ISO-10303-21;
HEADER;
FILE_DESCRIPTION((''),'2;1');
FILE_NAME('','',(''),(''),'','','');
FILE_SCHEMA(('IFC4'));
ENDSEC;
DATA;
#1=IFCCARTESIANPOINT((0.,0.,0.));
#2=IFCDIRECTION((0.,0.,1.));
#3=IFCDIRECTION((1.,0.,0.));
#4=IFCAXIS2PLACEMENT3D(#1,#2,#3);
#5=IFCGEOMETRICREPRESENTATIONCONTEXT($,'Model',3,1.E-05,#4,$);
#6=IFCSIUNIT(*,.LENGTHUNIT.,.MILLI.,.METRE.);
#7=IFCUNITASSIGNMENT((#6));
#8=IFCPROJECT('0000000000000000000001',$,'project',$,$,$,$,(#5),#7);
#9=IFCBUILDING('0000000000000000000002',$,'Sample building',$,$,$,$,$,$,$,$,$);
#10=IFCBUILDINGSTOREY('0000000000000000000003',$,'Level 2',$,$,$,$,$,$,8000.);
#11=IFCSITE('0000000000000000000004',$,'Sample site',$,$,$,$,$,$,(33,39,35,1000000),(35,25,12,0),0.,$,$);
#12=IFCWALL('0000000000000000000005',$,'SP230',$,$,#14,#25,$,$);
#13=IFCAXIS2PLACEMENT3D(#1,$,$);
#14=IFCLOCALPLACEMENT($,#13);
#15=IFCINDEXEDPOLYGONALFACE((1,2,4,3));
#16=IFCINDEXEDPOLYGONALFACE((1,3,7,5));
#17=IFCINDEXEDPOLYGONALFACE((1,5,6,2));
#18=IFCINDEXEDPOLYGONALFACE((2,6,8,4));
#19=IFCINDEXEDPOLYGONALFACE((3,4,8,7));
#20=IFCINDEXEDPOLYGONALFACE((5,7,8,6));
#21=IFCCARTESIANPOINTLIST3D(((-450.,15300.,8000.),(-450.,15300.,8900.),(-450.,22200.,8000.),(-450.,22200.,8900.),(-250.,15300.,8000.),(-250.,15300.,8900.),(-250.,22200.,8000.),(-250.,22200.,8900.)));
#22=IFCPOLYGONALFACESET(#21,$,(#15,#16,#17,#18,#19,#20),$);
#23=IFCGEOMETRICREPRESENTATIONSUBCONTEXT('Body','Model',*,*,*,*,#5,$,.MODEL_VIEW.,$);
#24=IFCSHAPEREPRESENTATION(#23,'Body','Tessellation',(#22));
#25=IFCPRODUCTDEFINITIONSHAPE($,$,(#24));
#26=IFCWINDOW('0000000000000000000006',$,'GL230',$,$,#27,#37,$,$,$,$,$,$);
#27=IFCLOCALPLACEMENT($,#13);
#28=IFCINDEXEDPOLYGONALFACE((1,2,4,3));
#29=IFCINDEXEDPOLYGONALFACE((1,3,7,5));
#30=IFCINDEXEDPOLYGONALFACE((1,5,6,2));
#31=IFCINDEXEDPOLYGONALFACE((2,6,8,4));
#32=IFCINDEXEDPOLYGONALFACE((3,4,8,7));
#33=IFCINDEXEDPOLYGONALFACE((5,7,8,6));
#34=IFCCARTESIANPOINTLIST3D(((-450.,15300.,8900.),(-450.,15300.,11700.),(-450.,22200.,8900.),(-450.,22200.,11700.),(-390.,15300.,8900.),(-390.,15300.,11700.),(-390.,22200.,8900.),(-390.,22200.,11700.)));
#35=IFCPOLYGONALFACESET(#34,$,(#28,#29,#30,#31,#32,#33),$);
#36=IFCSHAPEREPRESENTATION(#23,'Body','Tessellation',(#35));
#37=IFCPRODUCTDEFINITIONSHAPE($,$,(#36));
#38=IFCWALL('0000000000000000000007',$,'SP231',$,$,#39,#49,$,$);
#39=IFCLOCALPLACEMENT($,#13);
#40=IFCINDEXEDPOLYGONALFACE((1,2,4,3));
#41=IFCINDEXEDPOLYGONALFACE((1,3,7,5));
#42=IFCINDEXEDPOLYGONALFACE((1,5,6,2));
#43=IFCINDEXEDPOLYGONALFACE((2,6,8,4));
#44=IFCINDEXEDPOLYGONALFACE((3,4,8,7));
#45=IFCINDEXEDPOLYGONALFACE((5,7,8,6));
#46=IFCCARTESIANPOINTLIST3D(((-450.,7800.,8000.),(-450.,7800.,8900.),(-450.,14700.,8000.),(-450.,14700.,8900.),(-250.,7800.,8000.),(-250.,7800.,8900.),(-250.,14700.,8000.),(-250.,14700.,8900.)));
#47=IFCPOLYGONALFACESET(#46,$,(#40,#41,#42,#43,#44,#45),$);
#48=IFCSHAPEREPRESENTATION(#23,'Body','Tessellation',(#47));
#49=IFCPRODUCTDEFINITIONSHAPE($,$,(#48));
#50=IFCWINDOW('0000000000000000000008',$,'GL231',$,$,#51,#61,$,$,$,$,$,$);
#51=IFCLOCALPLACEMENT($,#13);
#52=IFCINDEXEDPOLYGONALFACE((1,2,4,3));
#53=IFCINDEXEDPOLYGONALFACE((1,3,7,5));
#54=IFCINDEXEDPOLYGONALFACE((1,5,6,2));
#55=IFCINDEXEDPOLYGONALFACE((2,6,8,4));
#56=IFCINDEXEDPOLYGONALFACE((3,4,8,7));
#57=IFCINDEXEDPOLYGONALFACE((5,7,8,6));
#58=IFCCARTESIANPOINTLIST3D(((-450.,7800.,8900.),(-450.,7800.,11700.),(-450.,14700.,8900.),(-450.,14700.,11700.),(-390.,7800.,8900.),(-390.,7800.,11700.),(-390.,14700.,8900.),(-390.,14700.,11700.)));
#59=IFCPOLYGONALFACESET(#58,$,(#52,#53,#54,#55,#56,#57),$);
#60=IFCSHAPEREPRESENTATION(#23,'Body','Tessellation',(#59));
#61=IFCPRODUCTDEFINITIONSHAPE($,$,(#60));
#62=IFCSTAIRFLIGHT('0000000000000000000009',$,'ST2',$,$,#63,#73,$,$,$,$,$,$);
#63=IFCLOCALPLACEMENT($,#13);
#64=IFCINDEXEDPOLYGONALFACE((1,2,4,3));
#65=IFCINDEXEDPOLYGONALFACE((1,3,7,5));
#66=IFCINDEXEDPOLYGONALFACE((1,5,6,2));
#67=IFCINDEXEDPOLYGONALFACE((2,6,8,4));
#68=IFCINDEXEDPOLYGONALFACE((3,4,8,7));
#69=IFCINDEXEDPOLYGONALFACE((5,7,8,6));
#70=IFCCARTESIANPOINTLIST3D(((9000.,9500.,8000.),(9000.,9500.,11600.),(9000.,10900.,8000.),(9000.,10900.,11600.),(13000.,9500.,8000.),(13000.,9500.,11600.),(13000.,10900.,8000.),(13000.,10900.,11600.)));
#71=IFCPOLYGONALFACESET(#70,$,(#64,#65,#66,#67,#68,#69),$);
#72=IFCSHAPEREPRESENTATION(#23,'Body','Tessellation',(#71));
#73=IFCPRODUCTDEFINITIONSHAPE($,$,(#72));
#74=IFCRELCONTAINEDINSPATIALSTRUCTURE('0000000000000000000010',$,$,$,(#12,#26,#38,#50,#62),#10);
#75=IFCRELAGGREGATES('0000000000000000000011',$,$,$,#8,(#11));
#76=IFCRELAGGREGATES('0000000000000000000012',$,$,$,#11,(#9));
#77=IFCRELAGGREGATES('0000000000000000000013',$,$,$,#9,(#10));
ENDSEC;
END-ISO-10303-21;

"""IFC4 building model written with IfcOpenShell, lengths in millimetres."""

from ifc_helpers import new_model, si_unit, frame, origin_with_axes, place, context, subcontext, project, spatial, indexed_curve, outline, extrude, element, save


model = new_model("IFC4")

# Units and contexts
model_context = context("Model", 3, precision=1e-05, world=origin_with_axes())
body_context = subcontext(model_context, "Body", "Model", "MODEL_VIEW")
ifc_project = project(units=[si_unit("LENGTHUNIT", "METRE", prefix="MILLI")], contexts=[model_context])

# Site, building, storey
site = spatial("IfcSite", under=ifc_project, Name="Sample site", RefLatitude=(33, 39, 35, 1000000), RefLongitude=(35, 25, 12, 0), RefElevation=0.0)
building = spatial("IfcBuilding", under=site, Name="Sample building")
storey = spatial("IfcBuildingStorey", under=building, Name="Level 2", Elevation=8000.0)

# Wall
wall_1_placement = place(None, frame((-450.0, 22200.0, 8000.0), z_axis=(0.0, 0.0, 1.0), x_axis=(0.0, -1.0, 0.0)))
element("IfcWall", 1, at=wall_1_placement, inside=storey, Name="SP230", context=body_context, shape_type="SweptSolid", body=[
    extrude(outline(indexed_curve([(0.0, 0.0), (0.0, 200.0), (6900.0, 200.0), (6900.0, 0.0), (0.0, 0.0)], self_intersect=False)), origin_with_axes(), (0.0, 0.0, 1.0), 900.0),
])

# Window
window_1_placement = place(None, frame((-450.0, 22200.0, 8900.0), z_axis=(0.0, 0.0, 1.0), x_axis=(0.0, -1.0, 0.0)))
element("IfcWindow", 2, at=window_1_placement, inside=storey, Name="GL230", context=body_context, shape_type="SweptSolid", body=[
    extrude(outline(indexed_curve([(0.0, 0.0), (0.0, 60.0), (6900.0, 60.0), (6900.0, 0.0), (0.0, 0.0)], self_intersect=False)), origin_with_axes(), (0.0, 0.0, 1.0), 2800.0),
])

# Wall
wall_2_placement = place(None, frame((-450.0, 14700.0, 8000.0), z_axis=(0.0, 0.0, 1.0), x_axis=(0.0, -1.0, 0.0)))
element("IfcWall", 3, at=wall_2_placement, inside=storey, Name="SP231", context=body_context, shape_type="SweptSolid", body=[
    extrude(outline(indexed_curve([(0.0, 0.0), (0.0, 200.0), (6900.0, 200.0), (6900.0, 0.0), (0.0, 0.0)], self_intersect=False)), origin_with_axes(), (0.0, 0.0, 1.0), 900.0),
])

# Window
window_2_placement = place(None, frame((-450.0, 14700.0, 8900.0), z_axis=(0.0, 0.0, 1.0), x_axis=(0.0, -1.0, 0.0)))
element("IfcWindow", 4, at=window_2_placement, inside=storey, Name="GL231", context=body_context, shape_type="SweptSolid", body=[
    extrude(outline(indexed_curve([(0.0, 0.0), (0.0, 60.0), (6900.0, 60.0), (6900.0, 0.0), (0.0, 0.0)], self_intersect=False)), origin_with_axes(), (0.0, 0.0, 1.0), 2800.0),
])

# Stair flight
stair_flight_placement = place(None, frame((9000.0, 9500.0, 8000.0), z_axis=(0.0, 0.0, 1.0), x_axis=(1.0, 0.0, 0.0)))
element("IfcStairFlight", 5, at=stair_flight_placement, inside=storey, Name="ST2", context=body_context, shape_type="SweptSolid", body=[
    extrude(outline(indexed_curve([(0.0, 0.0), (0.0, 1400.0), (4000.0, 1400.0), (4000.0, 0.0), (0.0, 0.0)], self_intersect=False)), origin_with_axes(), (0.0, 0.0, 1.0), 3600.0),
])

save(model, "model.ifc")
